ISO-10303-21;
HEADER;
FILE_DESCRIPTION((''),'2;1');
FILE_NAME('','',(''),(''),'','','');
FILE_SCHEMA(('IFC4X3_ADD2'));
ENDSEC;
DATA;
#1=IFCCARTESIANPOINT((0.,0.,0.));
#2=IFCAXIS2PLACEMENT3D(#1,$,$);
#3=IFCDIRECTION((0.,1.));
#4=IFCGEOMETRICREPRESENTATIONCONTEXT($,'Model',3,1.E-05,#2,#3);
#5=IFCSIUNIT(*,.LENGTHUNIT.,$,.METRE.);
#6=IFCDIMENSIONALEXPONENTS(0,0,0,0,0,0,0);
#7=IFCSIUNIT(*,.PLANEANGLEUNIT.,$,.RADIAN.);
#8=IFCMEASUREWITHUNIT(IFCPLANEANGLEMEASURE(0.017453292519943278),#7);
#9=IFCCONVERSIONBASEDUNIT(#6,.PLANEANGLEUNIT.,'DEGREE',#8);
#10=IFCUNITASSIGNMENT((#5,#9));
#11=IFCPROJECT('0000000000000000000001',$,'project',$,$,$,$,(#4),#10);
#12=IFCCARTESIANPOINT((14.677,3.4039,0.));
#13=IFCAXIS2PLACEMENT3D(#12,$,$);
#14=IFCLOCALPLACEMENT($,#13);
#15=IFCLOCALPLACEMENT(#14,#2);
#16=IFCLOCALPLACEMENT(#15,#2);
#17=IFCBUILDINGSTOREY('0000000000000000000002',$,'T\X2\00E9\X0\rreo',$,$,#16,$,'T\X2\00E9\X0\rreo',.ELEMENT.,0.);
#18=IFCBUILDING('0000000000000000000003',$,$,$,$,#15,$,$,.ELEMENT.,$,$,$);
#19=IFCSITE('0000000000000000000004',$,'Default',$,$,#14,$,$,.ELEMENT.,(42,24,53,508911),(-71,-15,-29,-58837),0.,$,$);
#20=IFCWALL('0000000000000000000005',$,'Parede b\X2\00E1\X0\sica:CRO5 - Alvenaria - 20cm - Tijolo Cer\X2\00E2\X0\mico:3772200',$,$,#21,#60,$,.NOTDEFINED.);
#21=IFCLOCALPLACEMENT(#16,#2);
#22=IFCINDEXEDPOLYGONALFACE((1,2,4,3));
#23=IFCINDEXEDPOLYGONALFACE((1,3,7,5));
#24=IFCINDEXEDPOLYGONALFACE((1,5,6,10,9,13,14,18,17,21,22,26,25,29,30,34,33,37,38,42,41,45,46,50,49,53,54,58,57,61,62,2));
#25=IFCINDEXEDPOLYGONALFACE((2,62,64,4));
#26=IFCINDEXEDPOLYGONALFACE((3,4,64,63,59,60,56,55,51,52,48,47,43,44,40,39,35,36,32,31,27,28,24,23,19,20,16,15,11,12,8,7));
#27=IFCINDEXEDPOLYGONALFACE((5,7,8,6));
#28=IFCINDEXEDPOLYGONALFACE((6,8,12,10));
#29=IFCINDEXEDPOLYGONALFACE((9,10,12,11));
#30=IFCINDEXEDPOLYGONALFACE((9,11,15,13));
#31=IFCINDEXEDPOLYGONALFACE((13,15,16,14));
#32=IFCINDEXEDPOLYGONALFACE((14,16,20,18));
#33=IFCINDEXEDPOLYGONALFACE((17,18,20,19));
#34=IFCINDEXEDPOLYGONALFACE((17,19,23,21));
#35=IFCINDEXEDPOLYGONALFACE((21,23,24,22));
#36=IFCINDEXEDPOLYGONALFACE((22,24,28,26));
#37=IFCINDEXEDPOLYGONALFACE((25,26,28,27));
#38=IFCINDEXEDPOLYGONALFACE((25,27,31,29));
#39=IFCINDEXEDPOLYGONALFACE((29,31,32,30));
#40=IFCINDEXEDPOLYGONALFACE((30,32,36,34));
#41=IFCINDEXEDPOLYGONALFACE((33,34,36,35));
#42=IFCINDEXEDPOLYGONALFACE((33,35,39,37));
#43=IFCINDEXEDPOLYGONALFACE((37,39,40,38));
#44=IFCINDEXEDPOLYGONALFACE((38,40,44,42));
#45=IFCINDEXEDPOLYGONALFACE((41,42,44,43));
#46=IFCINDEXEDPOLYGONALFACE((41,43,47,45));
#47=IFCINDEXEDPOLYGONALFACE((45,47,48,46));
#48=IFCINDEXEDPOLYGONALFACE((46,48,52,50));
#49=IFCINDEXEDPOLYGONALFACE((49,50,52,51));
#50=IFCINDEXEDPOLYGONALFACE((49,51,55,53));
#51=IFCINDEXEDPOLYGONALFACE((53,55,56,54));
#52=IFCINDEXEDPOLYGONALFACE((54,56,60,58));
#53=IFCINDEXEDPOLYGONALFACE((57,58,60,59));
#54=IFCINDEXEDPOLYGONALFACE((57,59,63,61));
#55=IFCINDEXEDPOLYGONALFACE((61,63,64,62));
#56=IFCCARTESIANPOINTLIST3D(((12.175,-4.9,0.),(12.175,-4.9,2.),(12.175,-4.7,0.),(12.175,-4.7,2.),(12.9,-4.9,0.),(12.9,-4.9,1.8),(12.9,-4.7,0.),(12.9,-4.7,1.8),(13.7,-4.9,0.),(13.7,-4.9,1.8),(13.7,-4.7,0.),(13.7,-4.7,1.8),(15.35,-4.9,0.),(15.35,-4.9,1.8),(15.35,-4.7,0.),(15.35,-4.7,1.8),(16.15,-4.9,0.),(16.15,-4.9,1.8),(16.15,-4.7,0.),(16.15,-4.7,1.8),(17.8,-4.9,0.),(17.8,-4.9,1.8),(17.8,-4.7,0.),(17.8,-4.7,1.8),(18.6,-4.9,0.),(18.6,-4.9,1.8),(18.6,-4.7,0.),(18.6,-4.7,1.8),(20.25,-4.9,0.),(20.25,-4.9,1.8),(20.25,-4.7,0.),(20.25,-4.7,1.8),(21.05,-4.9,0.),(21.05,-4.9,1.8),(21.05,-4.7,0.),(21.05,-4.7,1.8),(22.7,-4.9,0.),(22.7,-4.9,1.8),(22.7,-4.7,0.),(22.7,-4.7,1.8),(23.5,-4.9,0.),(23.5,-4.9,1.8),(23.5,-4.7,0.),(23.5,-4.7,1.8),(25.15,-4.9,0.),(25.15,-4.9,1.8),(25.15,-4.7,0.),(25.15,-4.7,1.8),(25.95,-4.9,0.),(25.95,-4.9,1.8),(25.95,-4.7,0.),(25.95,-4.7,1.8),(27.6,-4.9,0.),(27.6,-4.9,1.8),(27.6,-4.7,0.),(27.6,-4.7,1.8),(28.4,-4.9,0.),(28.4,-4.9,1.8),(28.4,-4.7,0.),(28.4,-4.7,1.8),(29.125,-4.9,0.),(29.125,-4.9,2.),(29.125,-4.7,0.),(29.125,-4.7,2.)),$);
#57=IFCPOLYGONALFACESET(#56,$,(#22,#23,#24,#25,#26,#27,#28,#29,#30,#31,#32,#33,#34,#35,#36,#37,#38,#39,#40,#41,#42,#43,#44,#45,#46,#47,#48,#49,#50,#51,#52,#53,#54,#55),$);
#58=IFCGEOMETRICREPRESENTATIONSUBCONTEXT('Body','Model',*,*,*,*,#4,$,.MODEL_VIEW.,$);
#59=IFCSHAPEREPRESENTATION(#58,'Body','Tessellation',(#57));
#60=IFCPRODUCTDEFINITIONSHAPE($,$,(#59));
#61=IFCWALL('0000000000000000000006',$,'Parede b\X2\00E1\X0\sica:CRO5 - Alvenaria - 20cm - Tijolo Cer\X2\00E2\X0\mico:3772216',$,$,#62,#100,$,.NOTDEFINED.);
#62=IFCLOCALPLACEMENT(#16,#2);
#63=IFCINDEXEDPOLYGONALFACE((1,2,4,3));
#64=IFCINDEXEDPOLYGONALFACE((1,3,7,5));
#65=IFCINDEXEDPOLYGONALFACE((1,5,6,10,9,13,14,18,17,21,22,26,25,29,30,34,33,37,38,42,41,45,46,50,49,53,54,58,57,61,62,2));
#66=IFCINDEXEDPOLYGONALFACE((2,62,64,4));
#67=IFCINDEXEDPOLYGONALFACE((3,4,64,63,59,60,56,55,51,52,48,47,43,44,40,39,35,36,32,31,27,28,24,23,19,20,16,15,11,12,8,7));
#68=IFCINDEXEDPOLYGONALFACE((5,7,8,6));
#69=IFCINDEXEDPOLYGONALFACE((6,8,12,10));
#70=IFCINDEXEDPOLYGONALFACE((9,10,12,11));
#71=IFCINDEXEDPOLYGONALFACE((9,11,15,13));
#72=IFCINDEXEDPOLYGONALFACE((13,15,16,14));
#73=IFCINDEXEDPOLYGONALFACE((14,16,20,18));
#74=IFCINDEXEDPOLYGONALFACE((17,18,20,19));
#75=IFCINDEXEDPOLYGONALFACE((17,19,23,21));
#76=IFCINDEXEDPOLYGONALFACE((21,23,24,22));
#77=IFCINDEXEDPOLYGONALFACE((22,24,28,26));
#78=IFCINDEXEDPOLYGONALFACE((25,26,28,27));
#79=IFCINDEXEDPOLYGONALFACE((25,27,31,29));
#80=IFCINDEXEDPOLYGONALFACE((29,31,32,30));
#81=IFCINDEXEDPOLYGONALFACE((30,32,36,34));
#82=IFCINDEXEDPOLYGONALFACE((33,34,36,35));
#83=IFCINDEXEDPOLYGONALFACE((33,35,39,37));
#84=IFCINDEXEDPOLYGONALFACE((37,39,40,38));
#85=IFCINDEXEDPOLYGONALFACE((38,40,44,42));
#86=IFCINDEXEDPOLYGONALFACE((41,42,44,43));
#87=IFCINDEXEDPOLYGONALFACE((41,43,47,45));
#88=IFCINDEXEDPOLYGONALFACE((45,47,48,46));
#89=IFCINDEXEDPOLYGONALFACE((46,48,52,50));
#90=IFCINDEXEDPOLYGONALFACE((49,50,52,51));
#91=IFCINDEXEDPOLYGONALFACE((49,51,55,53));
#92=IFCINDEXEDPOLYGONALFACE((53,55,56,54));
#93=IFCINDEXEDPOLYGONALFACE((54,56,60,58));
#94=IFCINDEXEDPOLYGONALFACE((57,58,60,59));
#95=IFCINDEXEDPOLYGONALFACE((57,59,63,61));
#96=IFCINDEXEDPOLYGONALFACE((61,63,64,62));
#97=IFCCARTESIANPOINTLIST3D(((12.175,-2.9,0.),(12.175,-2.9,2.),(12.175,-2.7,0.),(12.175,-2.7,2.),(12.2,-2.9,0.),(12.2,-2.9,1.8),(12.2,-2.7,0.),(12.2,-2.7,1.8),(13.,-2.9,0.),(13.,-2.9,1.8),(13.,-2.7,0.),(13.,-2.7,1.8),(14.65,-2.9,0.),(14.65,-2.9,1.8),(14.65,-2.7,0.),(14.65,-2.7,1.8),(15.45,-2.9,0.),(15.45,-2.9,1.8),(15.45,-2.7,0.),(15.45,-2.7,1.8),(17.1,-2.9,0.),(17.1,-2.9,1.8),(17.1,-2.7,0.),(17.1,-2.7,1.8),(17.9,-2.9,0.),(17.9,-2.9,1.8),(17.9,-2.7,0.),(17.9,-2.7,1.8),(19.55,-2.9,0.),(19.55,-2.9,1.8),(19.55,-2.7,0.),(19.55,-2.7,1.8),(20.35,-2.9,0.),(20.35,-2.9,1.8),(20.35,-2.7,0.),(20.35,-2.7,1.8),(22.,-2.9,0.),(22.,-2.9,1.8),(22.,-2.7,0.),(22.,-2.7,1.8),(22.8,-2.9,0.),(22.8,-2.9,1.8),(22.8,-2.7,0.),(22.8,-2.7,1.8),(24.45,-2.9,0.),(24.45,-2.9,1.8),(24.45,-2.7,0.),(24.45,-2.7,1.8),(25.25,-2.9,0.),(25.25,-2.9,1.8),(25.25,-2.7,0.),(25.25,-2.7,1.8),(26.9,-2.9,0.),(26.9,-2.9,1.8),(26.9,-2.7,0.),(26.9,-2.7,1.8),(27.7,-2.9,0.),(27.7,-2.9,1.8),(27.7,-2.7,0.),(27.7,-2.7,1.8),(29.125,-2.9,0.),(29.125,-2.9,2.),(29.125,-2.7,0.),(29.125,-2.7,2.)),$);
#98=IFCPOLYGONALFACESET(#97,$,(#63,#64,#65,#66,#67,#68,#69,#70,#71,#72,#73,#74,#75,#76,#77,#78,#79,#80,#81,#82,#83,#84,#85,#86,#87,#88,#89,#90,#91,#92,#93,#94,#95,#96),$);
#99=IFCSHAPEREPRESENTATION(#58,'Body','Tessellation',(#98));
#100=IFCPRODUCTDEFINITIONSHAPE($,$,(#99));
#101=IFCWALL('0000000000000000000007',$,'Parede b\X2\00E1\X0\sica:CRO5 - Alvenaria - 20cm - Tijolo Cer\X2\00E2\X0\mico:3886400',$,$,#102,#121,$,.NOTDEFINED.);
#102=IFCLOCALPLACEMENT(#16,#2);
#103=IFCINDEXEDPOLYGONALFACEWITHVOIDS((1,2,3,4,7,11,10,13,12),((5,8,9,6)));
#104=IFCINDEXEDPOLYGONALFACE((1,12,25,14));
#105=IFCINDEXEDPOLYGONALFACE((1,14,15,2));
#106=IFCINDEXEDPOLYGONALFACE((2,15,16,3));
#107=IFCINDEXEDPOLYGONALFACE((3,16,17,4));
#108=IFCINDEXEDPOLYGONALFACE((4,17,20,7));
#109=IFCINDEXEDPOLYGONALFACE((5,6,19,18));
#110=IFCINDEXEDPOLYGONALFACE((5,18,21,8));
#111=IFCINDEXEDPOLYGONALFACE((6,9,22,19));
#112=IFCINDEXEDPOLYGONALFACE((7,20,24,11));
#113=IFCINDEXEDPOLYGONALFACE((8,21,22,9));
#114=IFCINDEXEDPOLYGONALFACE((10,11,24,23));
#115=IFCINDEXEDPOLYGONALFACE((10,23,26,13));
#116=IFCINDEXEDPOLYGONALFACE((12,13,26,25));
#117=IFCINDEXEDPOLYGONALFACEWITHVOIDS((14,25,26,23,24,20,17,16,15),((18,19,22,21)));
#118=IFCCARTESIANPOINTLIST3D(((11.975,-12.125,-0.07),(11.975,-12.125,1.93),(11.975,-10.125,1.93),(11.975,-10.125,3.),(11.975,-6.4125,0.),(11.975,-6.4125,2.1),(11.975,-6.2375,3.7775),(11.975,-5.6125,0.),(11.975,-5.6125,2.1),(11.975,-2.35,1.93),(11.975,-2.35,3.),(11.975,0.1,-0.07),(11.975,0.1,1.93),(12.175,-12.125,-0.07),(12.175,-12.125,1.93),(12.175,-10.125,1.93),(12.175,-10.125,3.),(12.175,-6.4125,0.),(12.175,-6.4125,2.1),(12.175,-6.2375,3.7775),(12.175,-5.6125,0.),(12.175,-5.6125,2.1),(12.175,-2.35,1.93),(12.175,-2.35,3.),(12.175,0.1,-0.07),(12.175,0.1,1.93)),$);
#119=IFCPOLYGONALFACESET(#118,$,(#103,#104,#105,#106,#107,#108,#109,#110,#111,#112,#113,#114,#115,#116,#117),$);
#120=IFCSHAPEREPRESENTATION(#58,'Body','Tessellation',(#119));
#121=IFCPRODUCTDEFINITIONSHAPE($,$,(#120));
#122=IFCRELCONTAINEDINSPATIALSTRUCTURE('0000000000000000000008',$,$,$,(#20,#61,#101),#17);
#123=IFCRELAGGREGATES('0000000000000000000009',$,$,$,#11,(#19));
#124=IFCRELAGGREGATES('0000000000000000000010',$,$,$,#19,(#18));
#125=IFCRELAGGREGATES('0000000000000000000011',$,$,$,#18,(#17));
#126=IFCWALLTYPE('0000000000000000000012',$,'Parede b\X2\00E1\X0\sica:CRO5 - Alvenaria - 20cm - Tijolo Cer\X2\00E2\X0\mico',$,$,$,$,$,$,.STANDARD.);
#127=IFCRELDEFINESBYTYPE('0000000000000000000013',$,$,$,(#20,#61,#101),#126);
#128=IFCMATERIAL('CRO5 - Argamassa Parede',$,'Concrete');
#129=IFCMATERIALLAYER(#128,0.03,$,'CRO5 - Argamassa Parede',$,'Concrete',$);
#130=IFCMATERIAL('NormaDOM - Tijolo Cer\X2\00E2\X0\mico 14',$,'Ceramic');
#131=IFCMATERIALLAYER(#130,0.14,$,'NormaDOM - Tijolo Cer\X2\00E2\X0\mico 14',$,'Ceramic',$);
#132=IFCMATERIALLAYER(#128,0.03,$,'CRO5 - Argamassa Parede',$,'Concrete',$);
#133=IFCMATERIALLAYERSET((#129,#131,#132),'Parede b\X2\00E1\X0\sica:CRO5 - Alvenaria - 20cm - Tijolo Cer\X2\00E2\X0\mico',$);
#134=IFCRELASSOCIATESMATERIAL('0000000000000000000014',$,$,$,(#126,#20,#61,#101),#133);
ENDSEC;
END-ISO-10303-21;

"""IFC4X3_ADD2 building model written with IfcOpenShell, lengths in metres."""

from ifc_helpers import new_model, entity, si_unit, converted_unit, direction, frame, frame_2d, origin, place, context, subcontext, project, spatial, polyline, rectangle, extrude, clip, bounded_halfspace, material, layer, layer_set, type_object, element, save


model = new_model("IFC4X3_ADD2")

# Units and contexts
model_context = context("Model", 3, precision=1e-05, world=origin(), true_north=direction((0.0, 1.0)))
body_context = subcontext(model_context, "Body", "Model", "MODEL_VIEW")
ifc_project = project(units=[si_unit("LENGTHUNIT", "METRE"), converted_unit("PLANEANGLEUNIT", "DEGREE", entity("IfcPlaneAngleMeasure", 0.017453292519943278), si_unit("PLANEANGLEUNIT", "RADIAN"), dimensions=[0, 0, 0, 0, 0, 0, 0])], contexts=[model_context])

# Site, building, storey
site_placement = place(None, frame((14.677, 3.4039, 0.0)))
site = spatial("IfcSite", under=ifc_project, at=site_placement, Name="Default", CompositionType="ELEMENT", RefLatitude=(42, 24, 53, 508911), RefLongitude=(-71, -15, -29, -58837), RefElevation=0.0)
building_placement = place(site_placement, origin())
building = spatial("IfcBuilding", under=site, at=building_placement, CompositionType="ELEMENT")
storey_placement = place(building_placement, origin())
storey = spatial("IfcBuildingStorey", under=building, at=storey_placement, Name="Térreo", LongName="Térreo", CompositionType="ELEMENT", Elevation=0.0)

# Walls, openings
ifc_material_1 = material(Name="CRO5 - Argamassa Parede", Category="Concrete")
ifc_layer_1 = layer(ifc_material_1, 0.03, Name="CRO5 - Argamassa Parede", Category="Concrete")
ifc_material_2 = material(Name="NormaDOM - Tijolo Cerâmico 14", Category="Ceramic")
ifc_layer_2 = layer(ifc_material_2, 0.14, Name="NormaDOM - Tijolo Cerâmico 14", Category="Ceramic")
ifc_layer_3 = layer(ifc_material_1, 0.03, Name="CRO5 - Argamassa Parede", Category="Concrete")
ifc_layer_set = layer_set([ifc_layer_1, ifc_layer_2, ifc_layer_3], Name="Parede básica:CRO5 - Alvenaria - 20cm - Tijolo Cerâmico")
wall_type = type_object("IfcWallType", Name="Parede básica:CRO5 - Alvenaria - 20cm - Tijolo Cerâmico", PredefinedType="STANDARD", material=ifc_layer_set)
wall_1_placement = place(storey_placement, frame((12.175, -4.8, 0.0)))
wall_1 = element("IfcWall", 1, at=wall_1_placement, inside=storey, type_object=wall_type, material=ifc_layer_set, Name="Parede básica:CRO5 - Alvenaria - 20cm - Tijolo Cerâmico:3772200", PredefinedType="NOTDEFINED", context=body_context, shape_type="SweptSolid", body=[
    extrude(rectangle(XDim=16.95, YDim=0.2, at=frame_2d((8.475, 0.0), x_axis=(1.0, 0.0))), origin(), (0.0, 0.0, 1.0), 2.0),
])
opening_1_placement = place(wall_1_placement, frame((1.525, 0.1, 0.0)))
element("IfcOpeningElement", 2, at=opening_1_placement, cuts=wall_1, PredefinedType="OPENING", context=body_context, shape_type="SweptSolid", body=[
    extrude(rectangle(XDim=1.8, YDim=0.8, at=frame_2d((0.9, 0.4), x_axis=(1.0, 0.0))), frame((0.0, 0.0, 0.0), z_axis=(0.0, -1.0, 0.0), x_axis=(0.0, 0.0, 1.0)), (0.0, 0.0, 1.0), 0.2),
])
opening_2_placement = place(wall_1_placement, frame((16.225, 0.1, 0.0)))
element("IfcOpeningElement", 3, at=opening_2_placement, cuts=wall_1, PredefinedType="OPENING", context=body_context, shape_type="SweptSolid", body=[
    extrude(rectangle(XDim=1.8, YDim=0.8, at=frame_2d((0.9, 0.4), x_axis=(1.0, 0.0))), frame((0.0, 0.0, 0.0), z_axis=(0.0, -1.0, 0.0), x_axis=(0.0, 0.0, 1.0)), (0.0, 0.0, 1.0), 0.2),
])
opening_3_placement = place(wall_1_placement, frame((13.775, 0.1, 0.0)))
element("IfcOpeningElement", 4, at=opening_3_placement, cuts=wall_1, PredefinedType="OPENING", context=body_context, shape_type="SweptSolid", body=[
    extrude(rectangle(XDim=1.8, YDim=0.8, at=frame_2d((0.9, 0.4), x_axis=(1.0, 0.0))), frame((0.0, 0.0, 0.0), z_axis=(0.0, -1.0, 0.0), x_axis=(0.0, 0.0, 1.0)), (0.0, 0.0, 1.0), 0.2),
])
opening_4_placement = place(wall_1_placement, frame((11.325, 0.1, 0.0)))
element("IfcOpeningElement", 5, at=opening_4_placement, cuts=wall_1, PredefinedType="OPENING", context=body_context, shape_type="SweptSolid", body=[
    extrude(rectangle(XDim=1.8, YDim=0.8, at=frame_2d((0.9, 0.4), x_axis=(1.0, 0.0))), frame((0.0, 0.0, 0.0), z_axis=(0.0, -1.0, 0.0), x_axis=(0.0, 0.0, 1.0)), (0.0, 0.0, 1.0), 0.2),
])
opening_5_placement = place(wall_1_placement, frame((8.875, 0.1, 0.0)))
element("IfcOpeningElement", 6, at=opening_5_placement, cuts=wall_1, PredefinedType="OPENING", context=body_context, shape_type="SweptSolid", body=[
    extrude(rectangle(XDim=1.8, YDim=0.8, at=frame_2d((0.9, 0.4), x_axis=(1.0, 0.0))), frame((0.0, 0.0, 0.0), z_axis=(0.0, -1.0, 0.0), x_axis=(0.0, 0.0, 1.0)), (0.0, 0.0, 1.0), 0.2),
])
opening_6_placement = place(wall_1_placement, frame((6.425, 0.1, 0.0)))
element("IfcOpeningElement", 7, at=opening_6_placement, cuts=wall_1, PredefinedType="OPENING", context=body_context, shape_type="SweptSolid", body=[
    extrude(rectangle(XDim=1.8, YDim=0.8, at=frame_2d((0.9, 0.4), x_axis=(1.0, 0.0))), frame((0.0, 0.0, 0.0), z_axis=(0.0, -1.0, 0.0), x_axis=(0.0, 0.0, 1.0)), (0.0, 0.0, 1.0), 0.2),
])
opening_7_placement = place(wall_1_placement, frame((3.975, 0.1, 0.0)))
element("IfcOpeningElement", 8, at=opening_7_placement, cuts=wall_1, PredefinedType="OPENING", context=body_context, shape_type="SweptSolid", body=[
    extrude(rectangle(XDim=1.8, YDim=0.8, at=frame_2d((0.9, 0.4), x_axis=(1.0, 0.0))), frame((0.0, 0.0, 0.0), z_axis=(0.0, -1.0, 0.0), x_axis=(0.0, 0.0, 1.0)), (0.0, 0.0, 1.0), 0.2),
])
wall_2_placement = place(storey_placement, frame((12.175, -2.8, 0.0)))
wall_2 = element("IfcWall", 9, at=wall_2_placement, inside=storey, type_object=wall_type, material=ifc_layer_set, Name="Parede básica:CRO5 - Alvenaria - 20cm - Tijolo Cerâmico:3772216", PredefinedType="NOTDEFINED", context=body_context, shape_type="SweptSolid", body=[
    extrude(rectangle(XDim=16.95, YDim=0.2, at=frame_2d((8.475, 0.0), x_axis=(1.0, 0.0))), origin(), (0.0, 0.0, 1.0), 2.0),
])
opening_8_placement = place(wall_2_placement, frame((0.825, 0.1, 0.0)))
element("IfcOpeningElement", 10, at=opening_8_placement, cuts=wall_2, PredefinedType="OPENING", context=body_context, shape_type="SweptSolid", body=[
    extrude(rectangle(XDim=1.8, YDim=0.8, at=frame_2d((0.9, 0.4), x_axis=(1.0, 0.0))), frame((0.0, 0.0, 0.0), z_axis=(0.0, -1.0, 0.0), x_axis=(0.0, 0.0, 1.0)), (0.0, 0.0, 1.0), 0.2),
])
opening_9_placement = place(wall_2_placement, frame((3.275, 0.1, 0.0)))
element("IfcOpeningElement", 11, at=opening_9_placement, cuts=wall_2, PredefinedType="OPENING", context=body_context, shape_type="SweptSolid", body=[
    extrude(rectangle(XDim=1.8, YDim=0.8, at=frame_2d((0.9, 0.4), x_axis=(1.0, 0.0))), frame((0.0, 0.0, 0.0), z_axis=(0.0, -1.0, 0.0), x_axis=(0.0, 0.0, 1.0)), (0.0, 0.0, 1.0), 0.2),
])
opening_10_placement = place(wall_2_placement, frame((5.725, 0.1, 0.0)))
element("IfcOpeningElement", 12, at=opening_10_placement, cuts=wall_2, PredefinedType="OPENING", context=body_context, shape_type="SweptSolid", body=[
    extrude(rectangle(XDim=1.8, YDim=0.8, at=frame_2d((0.9, 0.4), x_axis=(1.0, 0.0))), frame((0.0, 0.0, 0.0), z_axis=(0.0, -1.0, 0.0), x_axis=(0.0, 0.0, 1.0)), (0.0, 0.0, 1.0), 0.2),
])
opening_11_placement = place(wall_2_placement, frame((8.175, 0.1, 0.0)))
element("IfcOpeningElement", 13, at=opening_11_placement, cuts=wall_2, PredefinedType="OPENING", context=body_context, shape_type="SweptSolid", body=[
    extrude(rectangle(XDim=1.8, YDim=0.8, at=frame_2d((0.9, 0.4), x_axis=(1.0, 0.0))), frame((0.0, 0.0, 0.0), z_axis=(0.0, -1.0, 0.0), x_axis=(0.0, 0.0, 1.0)), (0.0, 0.0, 1.0), 0.2),
])
opening_12_placement = place(wall_2_placement, frame((10.625, 0.1, 0.0)))
element("IfcOpeningElement", 14, at=opening_12_placement, cuts=wall_2, PredefinedType="OPENING", context=body_context, shape_type="SweptSolid", body=[
    extrude(rectangle(XDim=1.8, YDim=0.8, at=frame_2d((0.9, 0.4), x_axis=(1.0, 0.0))), frame((0.0, 0.0, 0.0), z_axis=(0.0, -1.0, 0.0), x_axis=(0.0, 0.0, 1.0)), (0.0, 0.0, 1.0), 0.2),
])
opening_13_placement = place(wall_2_placement, frame((13.075, 0.1, 0.0)))
element("IfcOpeningElement", 15, at=opening_13_placement, cuts=wall_2, PredefinedType="OPENING", context=body_context, shape_type="SweptSolid", body=[
    extrude(rectangle(XDim=1.8, YDim=0.8, at=frame_2d((0.9, 0.4), x_axis=(1.0, 0.0))), frame((0.0, 0.0, 0.0), z_axis=(0.0, -1.0, 0.0), x_axis=(0.0, 0.0, 1.0)), (0.0, 0.0, 1.0), 0.2),
])
opening_14_placement = place(wall_2_placement, frame((15.525, 0.1, 0.0)))
element("IfcOpeningElement", 16, at=opening_14_placement, cuts=wall_2, PredefinedType="OPENING", context=body_context, shape_type="SweptSolid", body=[
    extrude(rectangle(XDim=1.8, YDim=0.8, at=frame_2d((0.9, 0.4), x_axis=(1.0, 0.0))), frame((0.0, 0.0, 0.0), z_axis=(0.0, -1.0, 0.0), x_axis=(0.0, 0.0, 1.0)), (0.0, 0.0, 1.0), 0.2),
])
wall_3_placement = place(storey_placement, frame((12.075, 0.1, -0.07), z_axis=(0.0, 0.0, 1.0), x_axis=(0.0, -1.0, 0.0)))
wall_3 = element("IfcWall", 17, at=wall_3_placement, inside=storey, type_object=wall_type, material=ifc_layer_set, Name="Parede básica:CRO5 - Alvenaria - 20cm - Tijolo Cerâmico:3886400", PredefinedType="NOTDEFINED", context=body_context, shape_type="Clipping", body=[
    clip(clip(clip(clip(extrude(rectangle(XDim=12.225, YDim=0.2, at=frame_2d((6.1125, 0.0), x_axis=(-1.0, 0.0))), origin(), (0.0, 0.0, 1.0), 3.8475), bounded_halfspace(frame((2.45, 0.1, 3.07), z_axis=(-0.196116, 0.0, 0.980581), x_axis=(0.0, -1.0, 0.0)), False, frame((2.45, 0.1, 3.07)), polyline([(0.0, 0.0), (0.0, -0.2), (3.8875, -0.2), (3.8875, 0.0), (0.0, 0.0)]))), bounded_halfspace(frame((10.225, -0.1, 3.07), z_axis=(0.196116, 0.0, 0.980581), x_axis=(0.0, 1.0, 0.0)), False, frame((10.225, -0.1, 3.07)), polyline([(0.0, 0.0), (0.0, 0.2), (-3.8875, 0.2), (-3.8875, 0.0), (0.0, 0.0)]))), bounded_halfspace(frame((2.45, 0.1, 2.0), z_axis=(0.0, 0.0, 1.0), x_axis=(0.0, 1.0, 0.0)), False, frame((2.45, 0.1, 2.0)), polyline([(0.0, 0.0), (-2.25, 0.0), (-2.45, 0.0), (-2.45, -0.2), (0.0, -0.2), (0.0, 0.0)]))), bounded_halfspace(frame((10.225, -0.1, 2.0), z_axis=(0.0, 0.0, 1.0), x_axis=(0.0, 1.0, 0.0)), False, frame((10.225, -0.1, 2.0)), polyline([(0.0, 0.0), (2.0, 0.0), (2.0, 0.2), (1.8, 0.2), (0.0, 0.2), (0.0, 0.0)]))),
])
opening_15_placement = place(wall_3_placement, frame((0.1, -12.075, 0.07)))
element("IfcOpeningElement", 18, at=opening_15_placement, cuts=wall_3, PredefinedType="OPENING", context=body_context, shape_type="SweptSolid", body=[
    extrude(rectangle(XDim=1.8, YDim=0.2, at=frame_2d((0.0, 0.0), x_axis=(0.0, 1.0))), frame((2.8, 12.2, 0.9), z_axis=(0.0, 1.0, 0.0), x_axis=(-1.0, 0.0, 0.0)), (0.0, 0.0, 1.0), 0.8),
])
opening_16_placement = place(wall_3_placement, frame((5.7125, -0.1, 0.07)))
element("IfcOpeningElement", 19, at=opening_16_placement, cuts=wall_3, PredefinedType="OPENING", context=body_context, shape_type="SweptSolid", body=[
    extrude(rectangle(XDim=2.1, YDim=0.8, at=frame_2d((1.05, 0.4), x_axis=(1.0, 0.0))), frame((0.0, 0.0, 0.0), z_axis=(0.0, 1.0, 0.0), x_axis=(0.0, 0.0, 1.0)), (0.0, 0.0, 1.0), 0.2),
])

save(model, "model.ifc")
